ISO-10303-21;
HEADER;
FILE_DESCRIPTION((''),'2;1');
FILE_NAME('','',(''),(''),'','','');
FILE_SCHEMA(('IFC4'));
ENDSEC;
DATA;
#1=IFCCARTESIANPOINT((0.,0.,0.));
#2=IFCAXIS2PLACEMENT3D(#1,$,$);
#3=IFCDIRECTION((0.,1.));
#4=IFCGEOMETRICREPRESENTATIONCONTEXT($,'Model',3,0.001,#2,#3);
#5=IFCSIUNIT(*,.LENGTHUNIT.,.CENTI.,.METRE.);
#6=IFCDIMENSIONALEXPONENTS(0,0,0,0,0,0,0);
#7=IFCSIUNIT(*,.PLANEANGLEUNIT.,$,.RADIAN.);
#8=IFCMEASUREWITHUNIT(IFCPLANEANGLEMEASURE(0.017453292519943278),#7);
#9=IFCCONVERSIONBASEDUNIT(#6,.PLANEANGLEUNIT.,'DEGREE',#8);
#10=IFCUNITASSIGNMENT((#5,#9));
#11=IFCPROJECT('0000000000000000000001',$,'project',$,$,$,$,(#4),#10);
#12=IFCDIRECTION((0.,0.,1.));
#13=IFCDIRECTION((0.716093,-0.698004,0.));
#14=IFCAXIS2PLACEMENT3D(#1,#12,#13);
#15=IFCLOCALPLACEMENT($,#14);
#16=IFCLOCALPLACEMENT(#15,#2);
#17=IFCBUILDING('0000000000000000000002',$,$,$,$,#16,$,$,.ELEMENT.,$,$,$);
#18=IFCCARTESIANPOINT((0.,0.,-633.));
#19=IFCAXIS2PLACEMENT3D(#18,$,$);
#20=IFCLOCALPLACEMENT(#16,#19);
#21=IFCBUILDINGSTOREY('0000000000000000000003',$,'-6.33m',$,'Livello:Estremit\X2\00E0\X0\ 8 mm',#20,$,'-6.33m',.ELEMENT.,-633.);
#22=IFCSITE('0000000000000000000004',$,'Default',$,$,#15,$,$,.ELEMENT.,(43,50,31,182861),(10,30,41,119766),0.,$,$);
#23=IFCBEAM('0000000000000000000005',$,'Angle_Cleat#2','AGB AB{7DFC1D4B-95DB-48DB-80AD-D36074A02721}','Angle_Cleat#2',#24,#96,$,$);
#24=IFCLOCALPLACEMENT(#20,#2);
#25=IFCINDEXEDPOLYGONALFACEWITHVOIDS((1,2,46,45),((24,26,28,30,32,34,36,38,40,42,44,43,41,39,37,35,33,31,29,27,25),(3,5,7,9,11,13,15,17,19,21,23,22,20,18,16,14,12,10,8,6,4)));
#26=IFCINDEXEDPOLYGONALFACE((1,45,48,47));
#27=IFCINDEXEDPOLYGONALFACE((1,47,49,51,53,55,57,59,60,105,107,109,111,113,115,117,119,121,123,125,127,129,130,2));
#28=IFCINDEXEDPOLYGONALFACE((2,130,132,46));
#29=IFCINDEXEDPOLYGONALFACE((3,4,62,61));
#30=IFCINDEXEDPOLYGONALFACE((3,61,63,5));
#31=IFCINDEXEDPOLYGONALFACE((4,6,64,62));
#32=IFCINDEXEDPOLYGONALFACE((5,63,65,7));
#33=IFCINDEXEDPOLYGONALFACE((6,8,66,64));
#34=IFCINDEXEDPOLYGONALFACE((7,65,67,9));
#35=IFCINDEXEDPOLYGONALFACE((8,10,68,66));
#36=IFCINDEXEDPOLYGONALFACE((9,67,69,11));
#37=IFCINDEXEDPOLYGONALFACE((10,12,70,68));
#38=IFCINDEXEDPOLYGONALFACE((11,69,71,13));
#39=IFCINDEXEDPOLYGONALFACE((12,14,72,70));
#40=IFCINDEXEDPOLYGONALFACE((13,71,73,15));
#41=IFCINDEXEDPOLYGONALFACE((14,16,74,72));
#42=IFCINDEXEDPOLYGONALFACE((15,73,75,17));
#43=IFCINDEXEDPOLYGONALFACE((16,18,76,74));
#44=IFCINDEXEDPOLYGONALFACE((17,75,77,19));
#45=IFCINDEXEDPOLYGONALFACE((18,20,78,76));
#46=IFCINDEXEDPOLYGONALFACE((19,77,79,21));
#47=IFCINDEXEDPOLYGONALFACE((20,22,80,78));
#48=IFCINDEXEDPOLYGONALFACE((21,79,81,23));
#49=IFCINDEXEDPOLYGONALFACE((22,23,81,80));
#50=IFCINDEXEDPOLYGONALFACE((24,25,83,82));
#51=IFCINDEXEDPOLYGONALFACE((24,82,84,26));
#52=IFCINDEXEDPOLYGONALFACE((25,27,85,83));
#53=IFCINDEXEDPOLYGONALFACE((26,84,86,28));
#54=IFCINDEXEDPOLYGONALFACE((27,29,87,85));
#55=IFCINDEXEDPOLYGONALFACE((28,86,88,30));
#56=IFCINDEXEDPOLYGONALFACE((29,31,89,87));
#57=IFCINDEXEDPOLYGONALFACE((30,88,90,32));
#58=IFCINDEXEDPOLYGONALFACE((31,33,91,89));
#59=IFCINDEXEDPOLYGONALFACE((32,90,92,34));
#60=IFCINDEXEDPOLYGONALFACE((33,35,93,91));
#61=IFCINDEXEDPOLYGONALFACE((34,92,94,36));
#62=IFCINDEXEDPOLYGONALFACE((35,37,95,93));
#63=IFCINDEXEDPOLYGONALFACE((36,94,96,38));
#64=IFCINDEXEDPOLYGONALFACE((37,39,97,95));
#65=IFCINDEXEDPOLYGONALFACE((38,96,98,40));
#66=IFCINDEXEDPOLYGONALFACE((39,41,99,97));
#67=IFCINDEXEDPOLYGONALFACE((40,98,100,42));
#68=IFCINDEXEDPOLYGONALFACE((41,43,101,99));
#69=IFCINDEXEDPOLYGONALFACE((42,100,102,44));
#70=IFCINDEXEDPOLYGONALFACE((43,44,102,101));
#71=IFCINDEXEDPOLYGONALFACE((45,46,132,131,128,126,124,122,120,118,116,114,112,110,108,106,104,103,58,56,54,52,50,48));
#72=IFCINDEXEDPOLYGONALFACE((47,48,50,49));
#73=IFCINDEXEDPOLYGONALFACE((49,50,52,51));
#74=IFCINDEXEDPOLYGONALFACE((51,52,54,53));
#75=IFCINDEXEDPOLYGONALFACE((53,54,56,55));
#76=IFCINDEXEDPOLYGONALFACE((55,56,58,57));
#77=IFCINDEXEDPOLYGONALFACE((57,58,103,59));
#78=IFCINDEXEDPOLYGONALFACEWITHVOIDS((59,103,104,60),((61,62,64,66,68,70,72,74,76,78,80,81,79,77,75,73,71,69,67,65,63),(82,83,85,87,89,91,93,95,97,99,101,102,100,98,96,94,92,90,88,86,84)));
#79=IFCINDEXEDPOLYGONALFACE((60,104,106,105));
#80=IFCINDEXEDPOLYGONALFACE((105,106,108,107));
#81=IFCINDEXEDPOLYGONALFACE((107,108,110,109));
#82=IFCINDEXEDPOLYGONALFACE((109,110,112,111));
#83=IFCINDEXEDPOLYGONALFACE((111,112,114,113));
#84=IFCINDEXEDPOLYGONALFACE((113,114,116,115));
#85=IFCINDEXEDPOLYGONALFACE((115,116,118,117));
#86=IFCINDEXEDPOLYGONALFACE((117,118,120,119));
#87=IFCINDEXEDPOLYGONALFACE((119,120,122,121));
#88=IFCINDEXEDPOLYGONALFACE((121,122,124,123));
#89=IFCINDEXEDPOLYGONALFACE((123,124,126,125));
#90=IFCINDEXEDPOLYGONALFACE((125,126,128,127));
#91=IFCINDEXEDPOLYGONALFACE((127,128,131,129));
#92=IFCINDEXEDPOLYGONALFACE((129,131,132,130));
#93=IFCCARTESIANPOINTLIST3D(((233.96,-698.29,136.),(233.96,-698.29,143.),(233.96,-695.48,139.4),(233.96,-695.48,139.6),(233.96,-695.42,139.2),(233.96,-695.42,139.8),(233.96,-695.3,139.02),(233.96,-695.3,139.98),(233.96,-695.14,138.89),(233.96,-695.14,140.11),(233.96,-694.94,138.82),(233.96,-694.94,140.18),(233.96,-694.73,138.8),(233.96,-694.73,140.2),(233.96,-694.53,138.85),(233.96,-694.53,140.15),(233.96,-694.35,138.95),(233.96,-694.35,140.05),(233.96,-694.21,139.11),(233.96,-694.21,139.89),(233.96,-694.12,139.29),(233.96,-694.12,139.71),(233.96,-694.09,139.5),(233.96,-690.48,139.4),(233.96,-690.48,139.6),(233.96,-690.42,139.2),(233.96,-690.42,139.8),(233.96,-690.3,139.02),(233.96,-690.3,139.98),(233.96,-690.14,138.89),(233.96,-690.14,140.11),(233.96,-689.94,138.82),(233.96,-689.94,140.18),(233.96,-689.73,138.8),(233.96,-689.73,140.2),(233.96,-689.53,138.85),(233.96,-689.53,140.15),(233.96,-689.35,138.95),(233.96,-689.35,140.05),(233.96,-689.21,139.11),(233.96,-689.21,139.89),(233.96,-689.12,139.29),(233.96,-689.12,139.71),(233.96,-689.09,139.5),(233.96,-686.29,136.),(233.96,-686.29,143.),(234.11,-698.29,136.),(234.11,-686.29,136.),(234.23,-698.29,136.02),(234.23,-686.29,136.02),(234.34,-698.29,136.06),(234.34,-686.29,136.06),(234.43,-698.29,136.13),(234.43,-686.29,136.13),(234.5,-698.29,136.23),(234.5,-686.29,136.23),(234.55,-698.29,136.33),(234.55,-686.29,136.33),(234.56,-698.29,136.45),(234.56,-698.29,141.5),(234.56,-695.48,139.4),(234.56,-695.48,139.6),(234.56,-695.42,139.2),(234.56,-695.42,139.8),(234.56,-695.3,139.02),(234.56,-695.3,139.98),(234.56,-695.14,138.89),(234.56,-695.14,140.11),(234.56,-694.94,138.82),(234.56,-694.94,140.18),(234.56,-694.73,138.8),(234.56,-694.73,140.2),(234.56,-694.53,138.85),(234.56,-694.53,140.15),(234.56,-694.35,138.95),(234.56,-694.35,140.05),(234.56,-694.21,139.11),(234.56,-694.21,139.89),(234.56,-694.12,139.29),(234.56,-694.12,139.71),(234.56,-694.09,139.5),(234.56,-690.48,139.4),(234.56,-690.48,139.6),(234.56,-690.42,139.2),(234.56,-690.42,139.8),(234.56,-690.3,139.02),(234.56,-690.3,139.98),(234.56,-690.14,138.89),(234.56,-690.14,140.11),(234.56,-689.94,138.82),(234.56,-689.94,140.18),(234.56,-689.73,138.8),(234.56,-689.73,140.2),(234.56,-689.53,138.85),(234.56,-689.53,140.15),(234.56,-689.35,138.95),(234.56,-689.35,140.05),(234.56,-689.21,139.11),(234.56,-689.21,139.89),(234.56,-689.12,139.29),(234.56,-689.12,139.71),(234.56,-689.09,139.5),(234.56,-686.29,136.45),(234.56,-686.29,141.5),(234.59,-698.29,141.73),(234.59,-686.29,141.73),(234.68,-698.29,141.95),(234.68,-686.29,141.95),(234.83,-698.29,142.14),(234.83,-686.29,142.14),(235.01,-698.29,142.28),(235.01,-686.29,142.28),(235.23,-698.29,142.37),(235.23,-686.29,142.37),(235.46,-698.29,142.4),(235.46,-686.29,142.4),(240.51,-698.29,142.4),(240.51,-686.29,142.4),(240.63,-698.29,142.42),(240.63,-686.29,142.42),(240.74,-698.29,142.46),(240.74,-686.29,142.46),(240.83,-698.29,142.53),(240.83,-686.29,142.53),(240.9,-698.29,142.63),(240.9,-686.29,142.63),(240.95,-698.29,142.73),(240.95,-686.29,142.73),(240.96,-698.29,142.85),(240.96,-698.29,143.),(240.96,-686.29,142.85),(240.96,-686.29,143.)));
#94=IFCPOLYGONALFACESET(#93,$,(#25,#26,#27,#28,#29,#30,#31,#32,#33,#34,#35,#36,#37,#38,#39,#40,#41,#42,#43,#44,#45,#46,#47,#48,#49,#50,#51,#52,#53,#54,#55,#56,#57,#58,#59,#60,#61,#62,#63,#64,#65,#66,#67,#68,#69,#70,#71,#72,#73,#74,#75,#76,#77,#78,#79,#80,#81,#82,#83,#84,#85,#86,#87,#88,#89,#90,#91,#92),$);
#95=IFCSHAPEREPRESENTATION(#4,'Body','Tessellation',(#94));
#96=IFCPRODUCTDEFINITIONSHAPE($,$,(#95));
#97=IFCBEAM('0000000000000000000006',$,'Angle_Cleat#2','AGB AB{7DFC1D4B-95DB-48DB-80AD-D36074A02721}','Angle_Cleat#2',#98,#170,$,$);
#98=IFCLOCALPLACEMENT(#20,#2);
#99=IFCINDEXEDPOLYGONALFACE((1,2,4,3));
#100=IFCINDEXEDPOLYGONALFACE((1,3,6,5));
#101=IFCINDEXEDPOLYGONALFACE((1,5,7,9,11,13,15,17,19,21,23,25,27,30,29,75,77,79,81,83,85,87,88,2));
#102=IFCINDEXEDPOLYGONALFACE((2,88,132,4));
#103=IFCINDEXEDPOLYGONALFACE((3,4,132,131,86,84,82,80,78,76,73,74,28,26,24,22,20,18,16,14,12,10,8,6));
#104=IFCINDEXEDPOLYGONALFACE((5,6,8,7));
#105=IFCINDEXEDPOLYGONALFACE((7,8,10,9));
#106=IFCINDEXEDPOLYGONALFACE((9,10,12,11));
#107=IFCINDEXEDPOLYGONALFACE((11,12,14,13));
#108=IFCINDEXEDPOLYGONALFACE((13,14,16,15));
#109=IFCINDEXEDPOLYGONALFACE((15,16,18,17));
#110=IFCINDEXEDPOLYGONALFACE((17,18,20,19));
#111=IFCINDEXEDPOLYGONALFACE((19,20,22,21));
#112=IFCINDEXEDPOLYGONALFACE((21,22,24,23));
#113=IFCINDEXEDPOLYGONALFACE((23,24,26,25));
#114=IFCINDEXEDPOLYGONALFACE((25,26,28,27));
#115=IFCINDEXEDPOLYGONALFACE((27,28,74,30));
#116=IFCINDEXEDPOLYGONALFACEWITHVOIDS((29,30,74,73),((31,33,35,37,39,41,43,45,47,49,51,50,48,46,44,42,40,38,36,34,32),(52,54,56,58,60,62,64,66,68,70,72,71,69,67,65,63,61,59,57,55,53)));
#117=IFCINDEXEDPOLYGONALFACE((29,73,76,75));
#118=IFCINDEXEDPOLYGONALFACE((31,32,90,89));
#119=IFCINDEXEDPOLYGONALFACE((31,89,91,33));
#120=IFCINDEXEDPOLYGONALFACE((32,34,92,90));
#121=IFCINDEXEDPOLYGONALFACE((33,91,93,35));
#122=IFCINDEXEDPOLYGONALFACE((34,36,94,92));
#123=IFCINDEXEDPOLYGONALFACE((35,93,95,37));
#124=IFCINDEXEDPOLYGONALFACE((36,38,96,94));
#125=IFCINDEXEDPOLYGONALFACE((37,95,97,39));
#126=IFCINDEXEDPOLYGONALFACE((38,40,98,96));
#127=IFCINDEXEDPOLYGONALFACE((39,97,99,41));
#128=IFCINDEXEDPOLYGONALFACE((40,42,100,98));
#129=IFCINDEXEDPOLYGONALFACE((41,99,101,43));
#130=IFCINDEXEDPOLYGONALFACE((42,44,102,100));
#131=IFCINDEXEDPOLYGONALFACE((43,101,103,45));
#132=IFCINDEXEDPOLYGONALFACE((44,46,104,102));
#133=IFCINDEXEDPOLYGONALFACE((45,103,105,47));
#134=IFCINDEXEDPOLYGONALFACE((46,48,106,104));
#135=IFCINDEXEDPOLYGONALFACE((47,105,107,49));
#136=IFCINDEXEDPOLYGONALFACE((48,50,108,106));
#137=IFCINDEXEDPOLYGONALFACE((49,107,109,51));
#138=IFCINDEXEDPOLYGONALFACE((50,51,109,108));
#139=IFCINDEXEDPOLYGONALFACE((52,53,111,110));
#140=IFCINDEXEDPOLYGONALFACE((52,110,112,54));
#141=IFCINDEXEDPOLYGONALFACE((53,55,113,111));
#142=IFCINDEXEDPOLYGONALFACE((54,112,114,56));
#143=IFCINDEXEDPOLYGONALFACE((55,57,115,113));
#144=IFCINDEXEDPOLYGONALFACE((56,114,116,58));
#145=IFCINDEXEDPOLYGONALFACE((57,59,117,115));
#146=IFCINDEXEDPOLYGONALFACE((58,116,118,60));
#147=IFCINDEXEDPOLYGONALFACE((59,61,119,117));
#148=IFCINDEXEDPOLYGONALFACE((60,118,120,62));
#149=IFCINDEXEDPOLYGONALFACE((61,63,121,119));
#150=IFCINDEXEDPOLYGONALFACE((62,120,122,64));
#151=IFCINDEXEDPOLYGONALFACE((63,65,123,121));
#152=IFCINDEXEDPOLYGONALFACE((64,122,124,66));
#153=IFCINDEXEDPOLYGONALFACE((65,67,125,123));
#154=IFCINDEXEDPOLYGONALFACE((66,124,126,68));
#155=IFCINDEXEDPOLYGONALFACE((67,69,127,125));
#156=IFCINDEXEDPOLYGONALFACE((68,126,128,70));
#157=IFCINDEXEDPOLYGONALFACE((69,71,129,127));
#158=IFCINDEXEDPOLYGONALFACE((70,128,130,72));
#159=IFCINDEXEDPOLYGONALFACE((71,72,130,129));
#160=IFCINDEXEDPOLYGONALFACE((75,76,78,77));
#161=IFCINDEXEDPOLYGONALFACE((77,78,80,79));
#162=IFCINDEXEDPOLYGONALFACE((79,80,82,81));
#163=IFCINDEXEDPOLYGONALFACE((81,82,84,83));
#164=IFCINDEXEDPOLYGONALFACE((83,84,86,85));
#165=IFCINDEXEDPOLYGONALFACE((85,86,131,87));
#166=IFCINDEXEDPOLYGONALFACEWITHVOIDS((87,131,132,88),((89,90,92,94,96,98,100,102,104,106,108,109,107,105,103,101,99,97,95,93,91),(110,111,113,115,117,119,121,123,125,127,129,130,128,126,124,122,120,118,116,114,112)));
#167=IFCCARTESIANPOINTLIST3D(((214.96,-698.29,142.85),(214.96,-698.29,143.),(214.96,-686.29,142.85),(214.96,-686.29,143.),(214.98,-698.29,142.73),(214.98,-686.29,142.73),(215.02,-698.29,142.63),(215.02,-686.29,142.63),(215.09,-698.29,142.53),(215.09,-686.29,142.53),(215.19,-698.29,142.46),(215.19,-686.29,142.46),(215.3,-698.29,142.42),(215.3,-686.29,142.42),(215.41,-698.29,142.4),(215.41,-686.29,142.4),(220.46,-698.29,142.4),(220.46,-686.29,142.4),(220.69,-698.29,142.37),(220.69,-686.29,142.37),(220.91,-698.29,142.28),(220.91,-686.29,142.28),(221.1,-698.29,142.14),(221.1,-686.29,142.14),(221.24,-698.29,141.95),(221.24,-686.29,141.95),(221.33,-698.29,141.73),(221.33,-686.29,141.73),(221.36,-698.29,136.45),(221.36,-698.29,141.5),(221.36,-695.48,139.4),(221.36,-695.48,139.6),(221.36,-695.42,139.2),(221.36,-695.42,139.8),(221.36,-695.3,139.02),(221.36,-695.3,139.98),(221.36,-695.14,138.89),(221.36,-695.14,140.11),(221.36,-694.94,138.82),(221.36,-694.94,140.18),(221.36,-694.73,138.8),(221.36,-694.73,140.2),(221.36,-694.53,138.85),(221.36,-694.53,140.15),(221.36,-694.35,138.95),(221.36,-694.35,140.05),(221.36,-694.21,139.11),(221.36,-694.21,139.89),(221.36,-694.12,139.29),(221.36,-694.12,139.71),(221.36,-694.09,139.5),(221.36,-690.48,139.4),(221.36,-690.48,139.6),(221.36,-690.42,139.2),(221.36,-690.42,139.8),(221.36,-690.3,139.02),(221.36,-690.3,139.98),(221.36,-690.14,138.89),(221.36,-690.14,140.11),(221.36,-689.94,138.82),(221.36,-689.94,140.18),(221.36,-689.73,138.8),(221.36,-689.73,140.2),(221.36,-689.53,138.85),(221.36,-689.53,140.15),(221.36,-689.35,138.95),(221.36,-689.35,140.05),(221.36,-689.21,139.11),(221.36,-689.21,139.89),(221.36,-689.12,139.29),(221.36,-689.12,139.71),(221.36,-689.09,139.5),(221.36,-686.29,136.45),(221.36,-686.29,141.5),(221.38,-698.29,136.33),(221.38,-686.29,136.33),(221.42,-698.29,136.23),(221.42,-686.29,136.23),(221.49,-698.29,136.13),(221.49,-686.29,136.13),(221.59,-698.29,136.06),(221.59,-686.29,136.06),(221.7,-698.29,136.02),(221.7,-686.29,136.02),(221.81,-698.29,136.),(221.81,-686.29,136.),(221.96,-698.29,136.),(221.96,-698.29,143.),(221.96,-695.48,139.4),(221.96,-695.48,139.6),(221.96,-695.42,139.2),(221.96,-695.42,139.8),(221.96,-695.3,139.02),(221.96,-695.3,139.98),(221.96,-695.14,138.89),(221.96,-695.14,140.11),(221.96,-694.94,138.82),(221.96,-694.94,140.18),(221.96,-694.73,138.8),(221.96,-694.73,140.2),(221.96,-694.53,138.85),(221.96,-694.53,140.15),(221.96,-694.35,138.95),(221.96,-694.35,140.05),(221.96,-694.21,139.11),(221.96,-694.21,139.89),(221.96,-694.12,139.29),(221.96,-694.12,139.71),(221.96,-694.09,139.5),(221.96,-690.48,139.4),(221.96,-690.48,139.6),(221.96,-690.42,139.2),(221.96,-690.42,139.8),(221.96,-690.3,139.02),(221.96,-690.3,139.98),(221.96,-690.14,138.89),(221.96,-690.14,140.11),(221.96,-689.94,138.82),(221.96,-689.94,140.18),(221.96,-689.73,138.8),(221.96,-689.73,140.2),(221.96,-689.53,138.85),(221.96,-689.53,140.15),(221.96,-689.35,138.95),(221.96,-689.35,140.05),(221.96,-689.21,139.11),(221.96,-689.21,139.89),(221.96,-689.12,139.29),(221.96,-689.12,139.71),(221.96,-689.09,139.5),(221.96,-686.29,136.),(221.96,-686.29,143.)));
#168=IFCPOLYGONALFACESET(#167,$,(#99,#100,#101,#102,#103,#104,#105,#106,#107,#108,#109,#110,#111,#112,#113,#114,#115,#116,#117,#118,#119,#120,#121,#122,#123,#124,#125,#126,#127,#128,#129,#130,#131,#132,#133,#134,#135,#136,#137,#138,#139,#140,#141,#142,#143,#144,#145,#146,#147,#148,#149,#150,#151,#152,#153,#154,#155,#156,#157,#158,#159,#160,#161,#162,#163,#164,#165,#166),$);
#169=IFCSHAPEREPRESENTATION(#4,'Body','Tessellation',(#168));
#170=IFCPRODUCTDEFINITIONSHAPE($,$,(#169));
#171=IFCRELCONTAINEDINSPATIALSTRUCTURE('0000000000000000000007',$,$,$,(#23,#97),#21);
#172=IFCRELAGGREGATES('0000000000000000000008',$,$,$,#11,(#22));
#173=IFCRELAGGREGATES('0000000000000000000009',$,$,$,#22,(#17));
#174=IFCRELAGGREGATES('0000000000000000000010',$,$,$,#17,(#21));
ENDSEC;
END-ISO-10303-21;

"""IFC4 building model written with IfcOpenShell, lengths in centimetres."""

from ifc_helpers import new_model, entity, si_unit, converted_unit, direction, frame, frame_2d, origin, place, context, project, spatial, circle, l_section, extrude, element, save


model = new_model("IFC4")

# Units and contexts
model_context = context("Model", 3, precision=0.001, world=origin(), true_north=direction((0.0, 1.0)))
ifc_project = project(units=[si_unit("LENGTHUNIT", "METRE", prefix="CENTI"), converted_unit("PLANEANGLEUNIT", "DEGREE", entity("IfcPlaneAngleMeasure", 0.017453292519943278), si_unit("PLANEANGLEUNIT", "RADIAN"), dimensions=[0, 0, 0, 0, 0, 0, 0])], contexts=[model_context])

# Site, building, storey
site_placement = place(None, frame((0.0, 0.0, 0.0), z_axis=(0.0, 0.0, 1.0), x_axis=(0.716093, -0.698004, 0.0)))
site = spatial("IfcSite", under=ifc_project, at=site_placement, Name="Default", CompositionType="ELEMENT", RefLatitude=(43, 50, 31, 182861), RefLongitude=(10, 30, 41, 119766), RefElevation=0.0)
building_placement = place(site_placement, origin())
building = spatial("IfcBuilding", under=site, at=building_placement, CompositionType="ELEMENT")
storey_placement = place(building_placement, frame((0.0, 0.0, -633.0)))
storey = spatial("IfcBuildingStorey", under=building, at=storey_placement, Name="-6.33m", ObjectType="Livello:Estremità 8 mm", LongName="-6.33m", CompositionType="ELEMENT", Elevation=-633.0)

# Beams, openings
beam_1_placement = place(storey_placement, frame((235.89, -686.29, 141.07), z_axis=(0.0, 1.0, 0.0), x_axis=(1.0, 0.0, 0.0)))
beam_1 = element("IfcBeam", 1, at=beam_1_placement, inside=storey, Name="Angle_Cleat#2", Description="AGB AB{7DFC1D4B-95DB-48DB-80AD-D36074A02721}", ObjectType="Angle_Cleat#2", context=model_context, shape_type="SweptSolid", body=[
    extrude(l_section(Depth=7.0, Width=7.0, Thickness=0.6, FilletRadius=0.9, EdgeRadius=0.45, at=frame_2d((1.57, 1.57))), origin(), (0.0, 0.0, -1.0), 12.0),
])
opening_1_placement = place(beam_1_placement, frame((-1.98, 1.57, -6.0), z_axis=(1.0, 0.0, 0.0), x_axis=(0.0, 0.0, 1.0)))
element("IfcOpeningElement", 2, at=opening_1_placement, cuts=beam_1, ObjectType="Opening", context=model_context, shape_type="SweptSolid", body=[
    extrude(circle(Radius=0.7, at=frame_2d((2.5, 0.0), x_axis=(1.0, 0.0))), origin(), (0.0, 0.0, 1.0), 0.7),
])
opening_2_placement = place(beam_1_placement, frame((-1.98, 1.57, -6.0), z_axis=(1.0, 0.0, 0.0), x_axis=(0.0, 0.0, 1.0)))
element("IfcOpeningElement", 3, at=opening_2_placement, cuts=beam_1, ObjectType="Opening", context=model_context, shape_type="SweptSolid", body=[
    extrude(circle(Radius=0.7, at=frame_2d((-2.5, 0.0), x_axis=(1.0, 0.0))), origin(), (0.0, 0.0, 1.0), 0.7),
])
beam_2_placement = place(storey_placement, frame((220.03, -698.29, 141.07), z_axis=(0.0, -1.0, 0.0), x_axis=(-1.0, 0.0, 0.0)))
beam_2 = element("IfcBeam", 4, at=beam_2_placement, inside=storey, Name="Angle_Cleat#2", Description="AGB AB{7DFC1D4B-95DB-48DB-80AD-D36074A02721}", ObjectType="Angle_Cleat#2", context=model_context, shape_type="SweptSolid", body=[
    extrude(l_section(Depth=7.0, Width=7.0, Thickness=0.6, FilletRadius=0.9, EdgeRadius=0.45, at=frame_2d((1.57, 1.57))), origin(), (0.0, 0.0, -1.0), 12.0),
])
opening_3_placement = place(beam_2_placement, frame((-1.28, 1.57, -6.0), z_axis=(-1.0, 0.0, 0.0), x_axis=(0.0, 0.0, -1.0)))
element("IfcOpeningElement", 5, at=opening_3_placement, cuts=beam_2, ObjectType="Opening", context=model_context, shape_type="SweptSolid", body=[
    extrude(circle(Radius=0.7, at=frame_2d((2.5, 0.0), x_axis=(1.0, 0.0))), origin(), (0.0, 0.0, 1.0), 0.7),
])
opening_4_placement = place(beam_2_placement, frame((-1.28, 1.57, -6.0), z_axis=(-1.0, 0.0, 0.0), x_axis=(0.0, 0.0, -1.0)))
element("IfcOpeningElement", 6, at=opening_4_placement, cuts=beam_2, ObjectType="Opening", context=model_context, shape_type="SweptSolid", body=[
    extrude(circle(Radius=0.7, at=frame_2d((-2.5, 0.0), x_axis=(1.0, 0.0))), origin(), (0.0, 0.0, 1.0), 0.7),
])

save(model, "model.ifc")
